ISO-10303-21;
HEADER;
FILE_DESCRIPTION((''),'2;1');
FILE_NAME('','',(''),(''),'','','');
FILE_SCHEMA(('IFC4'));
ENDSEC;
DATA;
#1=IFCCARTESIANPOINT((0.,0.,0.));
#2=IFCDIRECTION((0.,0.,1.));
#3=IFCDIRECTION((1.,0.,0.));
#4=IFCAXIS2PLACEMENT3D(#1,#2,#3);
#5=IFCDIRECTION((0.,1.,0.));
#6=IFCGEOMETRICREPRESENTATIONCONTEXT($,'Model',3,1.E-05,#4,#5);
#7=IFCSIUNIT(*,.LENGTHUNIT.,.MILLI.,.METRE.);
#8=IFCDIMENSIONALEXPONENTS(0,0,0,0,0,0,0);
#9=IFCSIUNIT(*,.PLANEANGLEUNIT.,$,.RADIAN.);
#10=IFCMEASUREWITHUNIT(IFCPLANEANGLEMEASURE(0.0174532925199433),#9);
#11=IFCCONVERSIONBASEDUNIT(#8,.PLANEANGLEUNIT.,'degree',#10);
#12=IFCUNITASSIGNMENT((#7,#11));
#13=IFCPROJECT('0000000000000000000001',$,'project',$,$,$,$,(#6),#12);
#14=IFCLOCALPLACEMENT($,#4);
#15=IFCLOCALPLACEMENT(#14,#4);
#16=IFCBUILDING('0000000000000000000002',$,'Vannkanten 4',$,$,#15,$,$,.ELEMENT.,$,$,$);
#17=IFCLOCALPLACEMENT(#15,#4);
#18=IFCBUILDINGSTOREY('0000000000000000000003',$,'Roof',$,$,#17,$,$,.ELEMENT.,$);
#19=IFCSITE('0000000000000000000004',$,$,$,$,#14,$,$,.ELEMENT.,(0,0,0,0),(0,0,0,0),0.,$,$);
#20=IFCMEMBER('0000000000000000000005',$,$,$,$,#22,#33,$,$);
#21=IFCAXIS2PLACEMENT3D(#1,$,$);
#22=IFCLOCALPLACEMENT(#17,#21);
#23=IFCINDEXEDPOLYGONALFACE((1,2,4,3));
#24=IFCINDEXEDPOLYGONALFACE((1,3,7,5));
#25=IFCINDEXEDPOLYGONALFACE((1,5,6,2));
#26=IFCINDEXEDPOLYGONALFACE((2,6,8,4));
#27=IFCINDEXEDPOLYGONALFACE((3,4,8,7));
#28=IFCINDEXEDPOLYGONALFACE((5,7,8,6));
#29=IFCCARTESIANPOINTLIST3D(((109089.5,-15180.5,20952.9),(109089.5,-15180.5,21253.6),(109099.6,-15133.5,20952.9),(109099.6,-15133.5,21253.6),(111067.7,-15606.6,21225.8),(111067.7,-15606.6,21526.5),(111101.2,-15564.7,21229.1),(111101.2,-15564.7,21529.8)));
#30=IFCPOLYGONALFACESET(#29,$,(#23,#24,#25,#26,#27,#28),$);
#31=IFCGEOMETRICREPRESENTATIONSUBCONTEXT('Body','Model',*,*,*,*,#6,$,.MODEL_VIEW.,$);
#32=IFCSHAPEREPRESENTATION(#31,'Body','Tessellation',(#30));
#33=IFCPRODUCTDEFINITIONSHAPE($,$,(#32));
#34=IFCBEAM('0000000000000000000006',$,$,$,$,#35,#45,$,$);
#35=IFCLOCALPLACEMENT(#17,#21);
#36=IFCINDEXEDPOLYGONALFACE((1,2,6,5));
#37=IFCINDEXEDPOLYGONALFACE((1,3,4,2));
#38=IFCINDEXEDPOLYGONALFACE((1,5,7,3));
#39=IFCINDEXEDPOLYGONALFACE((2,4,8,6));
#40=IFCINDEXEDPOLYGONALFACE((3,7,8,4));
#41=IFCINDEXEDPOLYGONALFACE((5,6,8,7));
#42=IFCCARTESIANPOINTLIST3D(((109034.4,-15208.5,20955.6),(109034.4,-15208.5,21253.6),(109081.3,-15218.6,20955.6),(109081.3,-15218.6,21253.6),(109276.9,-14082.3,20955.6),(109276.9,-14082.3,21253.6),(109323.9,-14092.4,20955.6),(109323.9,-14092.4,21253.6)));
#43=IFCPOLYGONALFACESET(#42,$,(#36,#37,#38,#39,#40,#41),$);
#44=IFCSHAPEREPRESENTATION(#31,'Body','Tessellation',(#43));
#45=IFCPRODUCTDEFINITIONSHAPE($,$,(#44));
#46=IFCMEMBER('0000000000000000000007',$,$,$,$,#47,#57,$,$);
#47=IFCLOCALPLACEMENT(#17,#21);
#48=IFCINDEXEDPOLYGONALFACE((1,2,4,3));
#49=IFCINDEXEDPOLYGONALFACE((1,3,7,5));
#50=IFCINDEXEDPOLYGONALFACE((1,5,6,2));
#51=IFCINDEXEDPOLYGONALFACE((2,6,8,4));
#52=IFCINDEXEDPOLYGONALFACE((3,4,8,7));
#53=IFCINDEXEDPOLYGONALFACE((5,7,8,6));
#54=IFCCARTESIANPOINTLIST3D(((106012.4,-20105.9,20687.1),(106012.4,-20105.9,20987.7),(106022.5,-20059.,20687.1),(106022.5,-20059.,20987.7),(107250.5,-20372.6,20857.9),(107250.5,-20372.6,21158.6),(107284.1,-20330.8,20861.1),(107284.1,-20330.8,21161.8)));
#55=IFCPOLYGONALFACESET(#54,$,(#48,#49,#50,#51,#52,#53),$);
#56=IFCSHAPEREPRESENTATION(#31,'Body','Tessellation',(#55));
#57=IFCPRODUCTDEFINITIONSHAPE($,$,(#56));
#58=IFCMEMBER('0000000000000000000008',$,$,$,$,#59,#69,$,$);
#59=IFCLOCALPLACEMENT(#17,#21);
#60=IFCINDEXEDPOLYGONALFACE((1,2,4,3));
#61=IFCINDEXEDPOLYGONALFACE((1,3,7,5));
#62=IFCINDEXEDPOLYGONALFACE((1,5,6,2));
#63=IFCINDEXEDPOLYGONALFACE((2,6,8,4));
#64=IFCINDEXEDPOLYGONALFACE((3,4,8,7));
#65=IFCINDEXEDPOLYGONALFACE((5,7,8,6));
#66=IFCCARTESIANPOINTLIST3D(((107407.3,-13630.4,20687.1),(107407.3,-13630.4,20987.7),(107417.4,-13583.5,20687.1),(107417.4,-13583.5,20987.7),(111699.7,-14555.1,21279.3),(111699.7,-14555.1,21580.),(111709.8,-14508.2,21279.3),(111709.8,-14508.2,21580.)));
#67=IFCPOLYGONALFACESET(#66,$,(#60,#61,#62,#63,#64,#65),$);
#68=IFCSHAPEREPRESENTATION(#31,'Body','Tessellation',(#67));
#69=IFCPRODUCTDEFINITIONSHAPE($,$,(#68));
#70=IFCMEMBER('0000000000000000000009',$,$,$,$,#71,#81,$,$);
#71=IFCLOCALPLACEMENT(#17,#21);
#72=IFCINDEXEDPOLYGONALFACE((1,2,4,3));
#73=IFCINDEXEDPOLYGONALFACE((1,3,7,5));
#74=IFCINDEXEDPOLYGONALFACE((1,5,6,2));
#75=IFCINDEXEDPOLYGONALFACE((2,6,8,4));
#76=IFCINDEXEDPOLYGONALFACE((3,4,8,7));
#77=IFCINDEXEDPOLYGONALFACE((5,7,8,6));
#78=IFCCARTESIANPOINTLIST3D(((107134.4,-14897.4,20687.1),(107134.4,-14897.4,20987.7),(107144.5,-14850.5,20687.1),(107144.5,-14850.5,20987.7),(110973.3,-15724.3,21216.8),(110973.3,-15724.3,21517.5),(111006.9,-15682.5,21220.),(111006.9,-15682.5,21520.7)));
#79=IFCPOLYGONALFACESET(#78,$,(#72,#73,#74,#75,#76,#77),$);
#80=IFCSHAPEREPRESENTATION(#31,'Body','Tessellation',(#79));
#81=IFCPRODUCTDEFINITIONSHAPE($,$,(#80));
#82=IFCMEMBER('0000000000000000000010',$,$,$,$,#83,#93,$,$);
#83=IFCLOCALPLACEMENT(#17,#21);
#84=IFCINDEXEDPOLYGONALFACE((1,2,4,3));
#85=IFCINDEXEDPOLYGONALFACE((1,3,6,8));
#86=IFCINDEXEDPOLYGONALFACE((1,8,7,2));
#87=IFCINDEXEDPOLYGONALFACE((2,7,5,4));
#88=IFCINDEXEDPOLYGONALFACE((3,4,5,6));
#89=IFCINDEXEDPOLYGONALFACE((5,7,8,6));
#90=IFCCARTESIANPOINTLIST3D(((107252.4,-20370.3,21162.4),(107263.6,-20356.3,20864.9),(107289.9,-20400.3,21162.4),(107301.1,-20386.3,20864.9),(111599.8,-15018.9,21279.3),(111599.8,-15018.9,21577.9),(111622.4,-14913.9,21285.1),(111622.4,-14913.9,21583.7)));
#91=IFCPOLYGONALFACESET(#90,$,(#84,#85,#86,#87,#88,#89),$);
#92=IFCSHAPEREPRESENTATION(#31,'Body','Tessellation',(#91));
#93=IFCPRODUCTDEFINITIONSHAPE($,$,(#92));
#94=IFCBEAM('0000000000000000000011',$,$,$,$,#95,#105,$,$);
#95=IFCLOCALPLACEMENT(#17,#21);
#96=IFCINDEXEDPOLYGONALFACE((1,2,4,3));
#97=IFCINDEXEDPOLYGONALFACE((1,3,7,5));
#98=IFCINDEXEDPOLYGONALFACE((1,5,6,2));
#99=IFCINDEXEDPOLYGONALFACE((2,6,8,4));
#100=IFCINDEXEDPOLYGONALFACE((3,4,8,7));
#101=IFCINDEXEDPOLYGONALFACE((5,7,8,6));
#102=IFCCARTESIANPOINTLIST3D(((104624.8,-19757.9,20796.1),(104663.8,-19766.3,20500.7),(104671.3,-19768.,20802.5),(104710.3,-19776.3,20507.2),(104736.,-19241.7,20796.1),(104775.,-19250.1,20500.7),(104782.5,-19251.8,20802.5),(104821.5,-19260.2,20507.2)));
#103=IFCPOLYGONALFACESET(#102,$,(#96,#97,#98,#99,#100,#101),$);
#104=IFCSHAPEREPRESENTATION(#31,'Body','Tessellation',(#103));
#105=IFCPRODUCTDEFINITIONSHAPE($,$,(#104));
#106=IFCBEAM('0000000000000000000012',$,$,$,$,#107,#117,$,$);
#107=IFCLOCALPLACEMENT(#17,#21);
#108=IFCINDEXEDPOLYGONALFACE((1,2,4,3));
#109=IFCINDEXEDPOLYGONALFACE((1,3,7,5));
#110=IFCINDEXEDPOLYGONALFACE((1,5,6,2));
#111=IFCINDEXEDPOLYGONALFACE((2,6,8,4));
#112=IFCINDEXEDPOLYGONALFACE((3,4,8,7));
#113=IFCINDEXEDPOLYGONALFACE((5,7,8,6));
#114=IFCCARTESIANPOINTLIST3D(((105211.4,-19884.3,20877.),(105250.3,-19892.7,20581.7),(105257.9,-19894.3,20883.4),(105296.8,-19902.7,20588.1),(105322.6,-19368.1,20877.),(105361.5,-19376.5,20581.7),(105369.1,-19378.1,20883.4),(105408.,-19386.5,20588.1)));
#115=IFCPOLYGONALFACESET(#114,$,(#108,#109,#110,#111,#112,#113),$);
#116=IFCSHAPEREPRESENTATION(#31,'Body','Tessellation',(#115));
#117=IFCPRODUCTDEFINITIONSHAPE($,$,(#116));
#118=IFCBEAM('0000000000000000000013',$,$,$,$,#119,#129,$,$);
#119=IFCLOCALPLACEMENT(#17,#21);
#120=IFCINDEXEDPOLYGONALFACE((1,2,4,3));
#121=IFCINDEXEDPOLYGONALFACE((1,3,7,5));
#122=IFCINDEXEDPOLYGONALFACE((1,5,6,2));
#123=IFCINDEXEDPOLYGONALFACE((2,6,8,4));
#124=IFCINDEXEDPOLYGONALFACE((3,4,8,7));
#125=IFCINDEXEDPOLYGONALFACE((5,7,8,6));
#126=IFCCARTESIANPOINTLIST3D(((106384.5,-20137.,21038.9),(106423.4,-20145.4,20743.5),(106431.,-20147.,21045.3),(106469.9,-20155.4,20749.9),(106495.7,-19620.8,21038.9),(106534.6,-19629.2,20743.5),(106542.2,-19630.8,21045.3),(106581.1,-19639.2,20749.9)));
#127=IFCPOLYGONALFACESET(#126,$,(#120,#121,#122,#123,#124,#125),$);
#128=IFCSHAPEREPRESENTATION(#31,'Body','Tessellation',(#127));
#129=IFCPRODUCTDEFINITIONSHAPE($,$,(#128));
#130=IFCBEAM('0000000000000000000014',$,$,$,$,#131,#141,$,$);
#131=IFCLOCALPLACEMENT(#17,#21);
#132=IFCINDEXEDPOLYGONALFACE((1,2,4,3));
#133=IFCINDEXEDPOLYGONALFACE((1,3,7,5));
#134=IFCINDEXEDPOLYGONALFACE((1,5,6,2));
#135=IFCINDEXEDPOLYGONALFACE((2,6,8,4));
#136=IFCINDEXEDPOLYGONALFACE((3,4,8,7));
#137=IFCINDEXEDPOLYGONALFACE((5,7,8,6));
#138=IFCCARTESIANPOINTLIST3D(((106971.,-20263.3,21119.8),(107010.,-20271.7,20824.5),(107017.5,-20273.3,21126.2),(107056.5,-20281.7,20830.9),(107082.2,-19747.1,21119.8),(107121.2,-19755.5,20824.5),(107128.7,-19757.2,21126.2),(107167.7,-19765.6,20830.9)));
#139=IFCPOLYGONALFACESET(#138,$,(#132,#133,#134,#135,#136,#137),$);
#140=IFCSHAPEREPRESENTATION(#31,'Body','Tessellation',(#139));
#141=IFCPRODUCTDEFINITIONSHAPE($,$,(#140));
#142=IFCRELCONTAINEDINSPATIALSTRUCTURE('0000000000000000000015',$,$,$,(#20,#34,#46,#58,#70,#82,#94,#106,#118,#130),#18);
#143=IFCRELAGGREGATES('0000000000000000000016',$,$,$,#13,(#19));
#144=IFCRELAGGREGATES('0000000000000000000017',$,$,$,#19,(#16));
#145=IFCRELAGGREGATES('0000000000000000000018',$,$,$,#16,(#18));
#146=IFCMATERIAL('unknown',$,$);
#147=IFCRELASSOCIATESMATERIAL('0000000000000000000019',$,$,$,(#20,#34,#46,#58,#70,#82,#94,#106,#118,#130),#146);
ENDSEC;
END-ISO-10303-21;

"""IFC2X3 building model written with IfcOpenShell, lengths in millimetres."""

from ifc_helpers import new_model, entity, si_unit, converted_unit, direction, frame, origin_with_axes, place, context, subcontext, project, spatial, polyline, segment, composite_curve, outline, extrude, clip, halfspace, material, element, save


model = new_model("IFC2X3")

# Units and contexts
model_context = context("Model", 3, precision=1e-05, world=origin_with_axes(), true_north=direction((0.0, 1.0, 0.0)))
body_context = subcontext(model_context, "Body", "Model", "MODEL_VIEW")
ifc_project = project(units=[si_unit("LENGTHUNIT", "METRE", prefix="MILLI"), converted_unit("PLANEANGLEUNIT", "degree", entity("IfcPlaneAngleMeasure", 0.0174532925199433), si_unit("PLANEANGLEUNIT", "RADIAN"), dimensions=[0, 0, 0, 0, 0, 0, 0])], contexts=[model_context])

# Site, building, storey
site_placement = place(None, origin_with_axes())
site = spatial("IfcSite", under=ifc_project, at=site_placement, CompositionType="ELEMENT", RefLatitude=(0, 0, 0, 0), RefLongitude=(0, 0, 0, 0), RefElevation=0.0)
building_placement = place(site_placement, origin_with_axes())
building = spatial("IfcBuilding", under=site, at=building_placement, Name="Vannkanten 4", CompositionType="ELEMENT")
storey_placement = place(building_placement, origin_with_axes())
storey = spatial("IfcBuildingStorey", under=building, at=storey_placement, Name="Roof", CompositionType="ELEMENT")

# Shared definitions
ifc_material = material(Name="unknown")

# Member
member_1_placement = place(storey_placement, frame((109094.5, -15157.0, 21103.2), z_axis=(0.968803, -0.208692, 0.133675), x_axis=(0.210582, 0.977576, 0.0)))
element("IfcMember", 1, at=member_1_placement, inside=storey, material=ifc_material, context=body_context, shape_type="Clipping", body=[
    clip(clip(extrude(outline(composite_curve([segment(polyline([(-24.0, -149.0), (-24.0, 149.0), (24.0, 149.0), (24.0, -149.0), (-24.0, -149.0)]), True, "CONTINUOUS")], self_intersect=False)), frame((0.0, 0.0, -1073.2), z_axis=(0.0, 0.0, 1.0), x_axis=(1.0, 0.0, 0.0)), (0.0, 0.0, 1.0), 4212.5), halfspace(frame((-24.0, 149.0, 20.1), z_axis=(0.0, -0.133675, 0.991025), x_axis=(0.0, 0.991025, 0.133675)), True)), halfspace(frame((24.0, 149.0, 2086.1), z_axis=(0.446741, 0.119594, -0.886634), x_axis=(-0.893044, 0.0, -0.44997)), True)),
])

# Beam
beam_1_placement = place(storey_placement, frame((109300.4, -14087.3, 21104.6), z_axis=(-0.210582, -0.977576, 0.0), x_axis=(0.977576, -0.210582, 0.0)))
element("IfcBeam", 2, at=beam_1_placement, inside=storey, material=ifc_material, context=body_context, shape_type="SweptSolid", body=[
    extrude(outline(composite_curve([segment(polyline([(-24.0, -149.0), (-24.0, 149.0), (24.0, 149.0), (24.0, -149.0), (-24.0, -149.0)]), True, "CONTINUOUS")], self_intersect=False)), frame((0.0, 0.0, 0.0), z_axis=(0.0, 0.0, 1.0), x_axis=(1.0, 0.0, 0.0)), (0.0, 0.0, 1.0), 1152.0),
])

# Members
member_2_placement = place(storey_placement, frame((107267.3, -20351.7, 21009.9), z_axis=(-0.968803, 0.208692, -0.133675), x_axis=(-0.210582, -0.977576, 0.0)))
element("IfcMember", 3, at=member_2_placement, inside=storey, material=ifc_material, context=body_context, shape_type="Clipping", body=[
    clip(clip(extrude(outline(composite_curve([segment(polyline([(-24.0, -149.0), (-24.0, 149.0), (24.0, 149.0), (24.0, -149.0), (-24.0, -149.0)]), True, "CONTINUOUS")], self_intersect=False)), frame((0.0, 0.0, -703.4), z_axis=(0.0, 0.0, 1.0), x_axis=(1.0, 0.0, 0.0)), (0.0, 0.0, 1.0), 2684.8), halfspace(frame((-24.0, 149.0, -32.2), z_axis=(-0.446741, 0.119594, 0.886634), x_axis=(0.893044, 0.0, 0.44997)), True)), halfspace(frame((24.0, 149.0, 1270.0), z_axis=(0.0, -0.133675, -0.991025), x_axis=(0.0, -0.991025, 0.133675)), True)),
])
member_3_placement = place(storey_placement, frame((107412.3, -13607.0, 20837.4), z_axis=(0.968803, -0.208692, 0.133675), x_axis=(0.210582, 0.977576, 0.0)))
element("IfcMember", 4, at=member_3_placement, inside=storey, material=ifc_material, context=body_context, shape_type="Clipping", body=[
    clip(clip(extrude(outline(composite_curve([segment(polyline([(-24.0, -149.0), (-24.0, 149.0), (24.0, 149.0), (24.0, -149.0), (-24.0, -149.0)]), True, "CONTINUOUS")], self_intersect=False)), frame((0.0, 0.0, -2255.5), z_axis=(0.0, 0.0, 1.0), x_axis=(1.0, 0.0, 0.0)), (0.0, 0.0, 1.0), 8941.7), halfspace(frame((-24.0, 149.0, 20.1), z_axis=(0.0, -0.133675, 0.991025), x_axis=(0.0, 0.991025, 0.133675)), True)), halfspace(frame((24.0, 149.0, 4450.8), z_axis=(0.0, 0.133675, -0.991025), x_axis=(0.0, -0.991025, -0.133675)), True)),
])
member_4_placement = place(storey_placement, frame((107139.4, -14873.9, 20837.4), z_axis=(0.968803, -0.208692, 0.133675), x_axis=(0.210582, 0.977576, 0.0)))
element("IfcMember", 5, at=member_4_placement, inside=storey, material=ifc_material, context=body_context, shape_type="Clipping", body=[
    clip(clip(extrude(outline(composite_curve([segment(polyline([(-24.0, -149.0), (-24.0, 149.0), (24.0, 149.0), (24.0, -149.0), (-24.0, -149.0)]), True, "CONTINUOUS")], self_intersect=False)), frame((0.0, 0.0, -2033.6), z_axis=(0.0, 0.0, 1.0), x_axis=(1.0, 0.0, 0.0)), (0.0, 0.0, 1.0), 8054.0), halfspace(frame((-24.0, 149.0, 20.1), z_axis=(0.0, -0.133675, 0.991025), x_axis=(0.0, 0.991025, 0.133675)), True)), halfspace(frame((24.0, 149.0, 4006.9), z_axis=(0.446741, 0.119594, -0.886634), x_axis=(-0.893044, 0.0, -0.44997)), True)),
])
member_5_placement = place(storey_placement, frame((111611.1, -14966.4, 21431.5), z_axis=(-0.623991, -0.779113, -0.06015), x_axis=(0.780527, -0.625123, 0.0)))
element("IfcMember", 6, at=member_5_placement, inside=storey, material=ifc_material, context=body_context, shape_type="Clipping", body=[
    clip(extrude(outline(composite_curve([segment(polyline([(-24.0, -149.0), (-24.0, 149.0), (24.0, 149.0), (24.0, -149.0), (-24.0, -149.0)]), True, "CONTINUOUS")], self_intersect=False)), frame((0.0, 0.0, -3558.8), z_axis=(0.0, 0.0, 1.0), x_axis=(1.0, 0.0, 0.0)), (0.0, 0.0, 1.0), 10505.0), halfspace(frame((-24.0, 149.0, -57.1), z_axis=(-0.894664, 0.026871, 0.445932), x_axis=(0.446093, 0.0, 0.894987)), True)),
])

# Beams
beam_2_placement = place(storey_placement, frame((104667.6, -19767.1, 20651.6), z_axis=(0.210582, 0.977576, 0.0), x_axis=(-0.968803, 0.208692, -0.133675)))
element("IfcBeam", 7, at=beam_2_placement, inside=storey, material=ifc_material, context=body_context, shape_type="SweptSolid", body=[
    extrude(outline(composite_curve([segment(polyline([(-24.0, -149.0), (-24.0, 149.0), (24.0, 149.0), (24.0, -149.0), (-24.0, -149.0)]), True, "CONTINUOUS")], self_intersect=False)), frame((0.0, 0.0, 0.0), z_axis=(0.0, 0.0, 1.0), x_axis=(1.0, 0.0, 0.0)), (0.0, 0.0, 1.0), 528.0),
])
beam_3_placement = place(storey_placement, frame((105254.1, -19893.5, 20732.5), z_axis=(0.210582, 0.977576, 0.0), x_axis=(-0.968803, 0.208692, -0.133675)))
element("IfcBeam", 8, at=beam_3_placement, inside=storey, material=ifc_material, context=body_context, shape_type="SweptSolid", body=[
    extrude(outline(composite_curve([segment(polyline([(-24.0, -149.0), (-24.0, 149.0), (24.0, 149.0), (24.0, -149.0), (-24.0, -149.0)]), True, "CONTINUOUS")], self_intersect=False)), frame((0.0, 0.0, 0.0), z_axis=(0.0, 0.0, 1.0), x_axis=(1.0, 0.0, 0.0)), (0.0, 0.0, 1.0), 528.0),
])
beam_4_placement = place(storey_placement, frame((106427.2, -20146.2, 20894.4), z_axis=(0.210582, 0.977576, 0.0), x_axis=(-0.968803, 0.208692, -0.133675)))
element("IfcBeam", 9, at=beam_4_placement, inside=storey, material=ifc_material, context=body_context, shape_type="SweptSolid", body=[
    extrude(outline(composite_curve([segment(polyline([(-24.0, -149.0), (-24.0, 149.0), (24.0, 149.0), (24.0, -149.0), (-24.0, -149.0)]), True, "CONTINUOUS")], self_intersect=False)), frame((0.0, 0.0, 0.0), z_axis=(0.0, 0.0, 1.0), x_axis=(1.0, 0.0, 0.0)), (0.0, 0.0, 1.0), 528.0),
])
beam_5_placement = place(storey_placement, frame((107013.7, -20272.5, 20975.3), z_axis=(0.210582, 0.977576, 0.0), x_axis=(-0.968803, 0.208692, -0.133675)))
element("IfcBeam", 10, at=beam_5_placement, inside=storey, material=ifc_material, context=body_context, shape_type="SweptSolid", body=[
    extrude(outline(composite_curve([segment(polyline([(-24.0, -149.0), (-24.0, 149.0), (24.0, 149.0), (24.0, -149.0), (-24.0, -149.0)]), True, "CONTINUOUS")], self_intersect=False)), frame((0.0, 0.0, 0.0), z_axis=(0.0, 0.0, 1.0), x_axis=(1.0, 0.0, 0.0)), (0.0, 0.0, 1.0), 528.0),
])

save(model, "model.ifc")
